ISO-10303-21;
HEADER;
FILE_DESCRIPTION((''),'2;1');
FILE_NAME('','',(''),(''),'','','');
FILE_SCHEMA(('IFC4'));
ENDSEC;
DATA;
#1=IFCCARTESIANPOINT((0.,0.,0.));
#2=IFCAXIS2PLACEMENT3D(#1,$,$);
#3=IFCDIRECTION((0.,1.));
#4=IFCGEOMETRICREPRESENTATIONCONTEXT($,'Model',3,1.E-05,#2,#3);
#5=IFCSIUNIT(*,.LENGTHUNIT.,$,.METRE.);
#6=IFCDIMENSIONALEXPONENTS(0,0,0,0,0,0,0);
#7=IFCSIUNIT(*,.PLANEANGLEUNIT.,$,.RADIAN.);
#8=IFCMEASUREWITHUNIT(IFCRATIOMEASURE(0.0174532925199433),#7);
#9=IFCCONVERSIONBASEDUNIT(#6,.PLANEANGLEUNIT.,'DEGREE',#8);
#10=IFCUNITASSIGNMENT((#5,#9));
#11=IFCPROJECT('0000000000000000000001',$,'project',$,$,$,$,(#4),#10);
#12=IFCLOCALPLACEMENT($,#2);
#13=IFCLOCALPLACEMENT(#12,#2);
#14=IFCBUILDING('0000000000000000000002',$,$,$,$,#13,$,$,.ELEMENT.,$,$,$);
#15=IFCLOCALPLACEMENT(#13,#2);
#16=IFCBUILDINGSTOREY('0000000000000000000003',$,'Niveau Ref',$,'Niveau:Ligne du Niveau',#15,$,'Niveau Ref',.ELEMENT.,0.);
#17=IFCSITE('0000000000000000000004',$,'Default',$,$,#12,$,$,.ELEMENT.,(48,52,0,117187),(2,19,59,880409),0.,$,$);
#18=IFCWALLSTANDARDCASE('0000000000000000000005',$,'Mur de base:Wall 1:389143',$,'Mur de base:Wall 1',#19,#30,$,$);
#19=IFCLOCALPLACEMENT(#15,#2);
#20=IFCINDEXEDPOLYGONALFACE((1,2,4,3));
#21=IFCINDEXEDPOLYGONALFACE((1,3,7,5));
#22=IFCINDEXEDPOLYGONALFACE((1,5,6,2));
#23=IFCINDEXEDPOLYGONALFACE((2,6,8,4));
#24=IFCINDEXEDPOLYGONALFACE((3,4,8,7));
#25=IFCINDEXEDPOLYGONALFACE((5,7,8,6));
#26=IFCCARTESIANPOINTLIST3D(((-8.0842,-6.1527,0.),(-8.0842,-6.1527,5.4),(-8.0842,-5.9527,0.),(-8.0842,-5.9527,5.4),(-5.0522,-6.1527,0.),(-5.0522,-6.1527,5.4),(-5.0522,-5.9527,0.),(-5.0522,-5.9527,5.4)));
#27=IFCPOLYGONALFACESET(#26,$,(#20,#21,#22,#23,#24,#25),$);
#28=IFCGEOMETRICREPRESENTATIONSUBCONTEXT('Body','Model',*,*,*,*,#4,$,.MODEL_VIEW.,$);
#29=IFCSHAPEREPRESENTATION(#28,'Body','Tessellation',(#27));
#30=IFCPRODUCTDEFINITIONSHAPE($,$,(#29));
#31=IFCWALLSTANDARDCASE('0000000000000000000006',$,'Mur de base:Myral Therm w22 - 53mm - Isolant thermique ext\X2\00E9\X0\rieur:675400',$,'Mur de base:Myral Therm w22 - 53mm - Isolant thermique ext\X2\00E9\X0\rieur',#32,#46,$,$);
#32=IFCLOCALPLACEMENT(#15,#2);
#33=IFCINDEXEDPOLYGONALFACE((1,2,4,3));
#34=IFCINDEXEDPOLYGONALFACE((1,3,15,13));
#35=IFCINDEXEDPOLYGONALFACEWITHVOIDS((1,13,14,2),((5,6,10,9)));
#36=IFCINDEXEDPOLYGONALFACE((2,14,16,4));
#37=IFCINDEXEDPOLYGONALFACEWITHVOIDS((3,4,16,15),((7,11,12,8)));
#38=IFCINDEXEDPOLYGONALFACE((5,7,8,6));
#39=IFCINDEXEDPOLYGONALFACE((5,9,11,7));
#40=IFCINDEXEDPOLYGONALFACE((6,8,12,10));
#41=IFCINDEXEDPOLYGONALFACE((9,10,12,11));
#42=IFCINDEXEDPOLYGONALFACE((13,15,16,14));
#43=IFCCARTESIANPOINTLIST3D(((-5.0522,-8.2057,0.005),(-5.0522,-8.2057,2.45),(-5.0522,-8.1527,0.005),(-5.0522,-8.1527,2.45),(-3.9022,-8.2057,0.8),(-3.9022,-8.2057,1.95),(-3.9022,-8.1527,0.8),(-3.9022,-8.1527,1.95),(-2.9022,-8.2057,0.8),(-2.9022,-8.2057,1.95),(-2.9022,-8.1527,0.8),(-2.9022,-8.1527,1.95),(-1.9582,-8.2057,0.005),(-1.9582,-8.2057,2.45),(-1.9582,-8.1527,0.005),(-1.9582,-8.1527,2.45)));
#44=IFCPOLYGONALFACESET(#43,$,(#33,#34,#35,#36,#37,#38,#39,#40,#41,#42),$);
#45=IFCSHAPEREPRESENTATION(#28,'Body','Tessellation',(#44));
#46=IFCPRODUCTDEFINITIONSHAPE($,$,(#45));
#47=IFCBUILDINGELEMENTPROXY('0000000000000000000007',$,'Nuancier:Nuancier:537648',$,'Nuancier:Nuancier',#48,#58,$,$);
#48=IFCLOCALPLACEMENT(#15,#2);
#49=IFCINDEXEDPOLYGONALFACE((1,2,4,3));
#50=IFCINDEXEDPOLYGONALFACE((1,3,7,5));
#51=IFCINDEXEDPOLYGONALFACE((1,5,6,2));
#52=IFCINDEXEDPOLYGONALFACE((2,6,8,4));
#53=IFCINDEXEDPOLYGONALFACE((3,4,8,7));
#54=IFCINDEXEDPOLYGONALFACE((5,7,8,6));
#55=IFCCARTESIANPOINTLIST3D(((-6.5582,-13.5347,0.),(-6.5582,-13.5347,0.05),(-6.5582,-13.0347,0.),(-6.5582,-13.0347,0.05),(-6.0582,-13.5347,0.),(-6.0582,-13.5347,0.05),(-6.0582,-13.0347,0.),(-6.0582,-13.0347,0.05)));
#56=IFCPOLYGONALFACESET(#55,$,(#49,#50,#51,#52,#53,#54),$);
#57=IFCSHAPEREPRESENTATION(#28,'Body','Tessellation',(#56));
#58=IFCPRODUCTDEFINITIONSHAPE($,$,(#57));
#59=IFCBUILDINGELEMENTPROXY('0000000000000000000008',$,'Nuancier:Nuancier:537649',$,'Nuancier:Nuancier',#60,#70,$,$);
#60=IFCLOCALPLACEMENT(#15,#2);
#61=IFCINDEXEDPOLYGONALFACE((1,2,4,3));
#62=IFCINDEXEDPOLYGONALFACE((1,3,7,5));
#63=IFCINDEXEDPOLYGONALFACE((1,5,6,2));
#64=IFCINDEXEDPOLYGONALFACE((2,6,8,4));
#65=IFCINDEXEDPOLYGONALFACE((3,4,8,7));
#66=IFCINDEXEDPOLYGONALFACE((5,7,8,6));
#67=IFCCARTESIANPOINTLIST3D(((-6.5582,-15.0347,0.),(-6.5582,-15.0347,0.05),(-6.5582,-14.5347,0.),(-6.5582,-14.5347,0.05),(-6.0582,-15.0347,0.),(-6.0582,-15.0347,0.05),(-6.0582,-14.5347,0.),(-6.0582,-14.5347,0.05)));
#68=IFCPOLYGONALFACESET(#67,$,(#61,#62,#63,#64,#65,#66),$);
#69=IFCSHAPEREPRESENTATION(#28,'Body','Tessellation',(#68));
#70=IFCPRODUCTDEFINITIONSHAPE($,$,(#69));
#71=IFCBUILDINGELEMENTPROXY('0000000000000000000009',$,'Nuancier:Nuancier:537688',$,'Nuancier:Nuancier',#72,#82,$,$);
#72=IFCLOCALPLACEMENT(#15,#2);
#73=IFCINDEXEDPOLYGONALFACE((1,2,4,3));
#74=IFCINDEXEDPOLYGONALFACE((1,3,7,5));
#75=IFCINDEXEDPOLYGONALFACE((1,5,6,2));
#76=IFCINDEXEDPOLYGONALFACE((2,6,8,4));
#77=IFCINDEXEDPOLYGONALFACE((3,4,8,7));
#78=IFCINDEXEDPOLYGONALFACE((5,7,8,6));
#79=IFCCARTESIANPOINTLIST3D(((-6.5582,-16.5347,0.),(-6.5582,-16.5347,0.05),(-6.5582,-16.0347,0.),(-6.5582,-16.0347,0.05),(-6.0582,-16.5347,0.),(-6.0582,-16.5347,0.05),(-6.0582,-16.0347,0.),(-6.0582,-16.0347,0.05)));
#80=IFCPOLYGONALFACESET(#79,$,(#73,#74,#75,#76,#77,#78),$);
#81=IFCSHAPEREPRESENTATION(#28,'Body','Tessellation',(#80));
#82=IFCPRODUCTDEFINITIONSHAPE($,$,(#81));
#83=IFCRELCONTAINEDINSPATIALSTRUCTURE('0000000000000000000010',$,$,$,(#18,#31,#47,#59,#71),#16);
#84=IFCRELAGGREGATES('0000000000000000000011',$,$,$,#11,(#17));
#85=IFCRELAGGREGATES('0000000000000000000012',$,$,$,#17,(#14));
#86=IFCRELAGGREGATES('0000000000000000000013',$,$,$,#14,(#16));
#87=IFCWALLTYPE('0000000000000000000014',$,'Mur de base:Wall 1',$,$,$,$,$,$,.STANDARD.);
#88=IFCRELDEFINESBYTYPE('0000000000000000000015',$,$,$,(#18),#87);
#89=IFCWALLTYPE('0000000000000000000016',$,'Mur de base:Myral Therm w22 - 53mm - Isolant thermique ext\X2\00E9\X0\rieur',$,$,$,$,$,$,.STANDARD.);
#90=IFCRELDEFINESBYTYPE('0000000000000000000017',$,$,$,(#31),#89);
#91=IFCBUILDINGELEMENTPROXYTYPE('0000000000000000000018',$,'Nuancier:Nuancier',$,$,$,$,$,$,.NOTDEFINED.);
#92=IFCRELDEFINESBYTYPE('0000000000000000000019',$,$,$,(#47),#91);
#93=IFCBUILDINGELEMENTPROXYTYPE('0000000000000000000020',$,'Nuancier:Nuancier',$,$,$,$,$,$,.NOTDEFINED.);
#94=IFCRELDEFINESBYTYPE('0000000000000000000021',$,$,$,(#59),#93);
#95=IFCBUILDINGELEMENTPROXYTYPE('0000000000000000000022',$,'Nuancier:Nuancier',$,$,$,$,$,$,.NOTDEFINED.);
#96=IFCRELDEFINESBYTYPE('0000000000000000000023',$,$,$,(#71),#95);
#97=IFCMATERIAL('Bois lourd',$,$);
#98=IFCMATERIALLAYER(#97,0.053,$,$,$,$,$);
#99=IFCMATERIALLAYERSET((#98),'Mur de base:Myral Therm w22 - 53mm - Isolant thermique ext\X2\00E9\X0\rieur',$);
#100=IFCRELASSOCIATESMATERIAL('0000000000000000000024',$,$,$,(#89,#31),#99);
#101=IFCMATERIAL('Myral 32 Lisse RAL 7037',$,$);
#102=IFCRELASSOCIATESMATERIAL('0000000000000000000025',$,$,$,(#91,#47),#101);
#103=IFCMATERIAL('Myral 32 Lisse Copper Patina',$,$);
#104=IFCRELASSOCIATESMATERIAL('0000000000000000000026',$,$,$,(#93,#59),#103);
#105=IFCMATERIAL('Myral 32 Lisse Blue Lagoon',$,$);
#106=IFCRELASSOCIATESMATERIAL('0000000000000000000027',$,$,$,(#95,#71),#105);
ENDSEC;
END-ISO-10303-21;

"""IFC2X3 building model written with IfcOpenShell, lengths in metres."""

from ifc_helpers import new_model, entity, si_unit, converted_unit, direction, frame, frame_2d, origin, origin_2d_with_axis, place, context, subcontext, project, spatial, rectangle, extrude, source, transform, mapped, material, layer, layer_set, layer_usage, type_object, type_shapes, element, save


model = new_model("IFC2X3")

# Units and contexts
model_context = context("Model", 3, precision=1e-05, world=origin(), true_north=direction((0.0, 1.0)))
body_context = subcontext(model_context, "Body", "Model", "MODEL_VIEW")
ifc_project = project(units=[si_unit("LENGTHUNIT", "METRE"), converted_unit("PLANEANGLEUNIT", "DEGREE", entity("IfcRatioMeasure", 0.0174532925199433), si_unit("PLANEANGLEUNIT", "RADIAN"), dimensions=[0, 0, 0, 0, 0, 0, 0])], contexts=[model_context])

# Site, building, storey
site_placement = place(None, origin())
site = spatial("IfcSite", under=ifc_project, at=site_placement, Name="Default", CompositionType="ELEMENT", RefLatitude=(48, 52, 0, 117187), RefLongitude=(2, 19, 59, 880409), RefElevation=0.0)
building_placement = place(site_placement, origin())
building = spatial("IfcBuilding", under=site, at=building_placement, CompositionType="ELEMENT")
storey_placement = place(building_placement, origin())
storey = spatial("IfcBuildingStorey", under=building, at=storey_placement, Name="Niveau Ref", ObjectType="Niveau:Ligne du Niveau", LongName="Niveau Ref", CompositionType="ELEMENT", Elevation=0.0)

# Wall
wall_type_1 = type_object("IfcWallType", Name="Mur de base:Wall 1", PredefinedType="STANDARD")
wall_1_placement = place(storey_placement, frame((-5.0522, -6.0527, 0.0), z_axis=(0.0, 0.0, 1.0), x_axis=(-1.0, 0.0, 0.0)))
element("IfcWallStandardCase", 1, at=wall_1_placement, inside=storey, type_object=wall_type_1, Name="Mur de base:Wall 1:389143", ObjectType="Mur de base:Wall 1", context=body_context, shape_type="SweptSolid", body=[
    extrude(rectangle(XDim=3.032, YDim=0.2, at=frame_2d((1.516, 0.0), x_axis=(-1.0, 0.0))), origin(), (0.0, 0.0, 1.0), 5.4),
])

# Wall, opening
ifc_material_1 = material(Name="Bois lourd")
ifc_layer = layer(ifc_material_1, 0.053)
ifc_layer_set = layer_set([ifc_layer], Name="Mur de base:Myral Therm w22 - 53mm - Isolant thermique extérieur")
ifc_layer_usage = layer_usage(ifc_layer_set, "AXIS2", "NEGATIVE", 0.0265)
wall_type_2 = type_object("IfcWallType", Name="Mur de base:Myral Therm w22 - 53mm - Isolant thermique extérieur", PredefinedType="STANDARD", material=ifc_layer_set)
wall_2_placement = place(storey_placement, frame((-5.0522, -8.1792, 0.005)))
wall_2 = element("IfcWallStandardCase", 2, at=wall_2_placement, inside=storey, type_object=wall_type_2, material=ifc_layer_usage, Name="Mur de base:Myral Therm w22 - 53mm - Isolant thermique extérieur:675400", ObjectType="Mur de base:Myral Therm w22 - 53mm - Isolant thermique extérieur", context=body_context, shape_type="SweptSolid", body=[
    extrude(rectangle(XDim=3.094, YDim=0.053, at=frame_2d((1.547, 0.0), x_axis=(-1.0, 0.0))), origin(), (0.0, 0.0, 1.0), 2.445),
])
opening_placement = place(wall_2_placement, origin())
element("IfcOpeningElement", 3, at=opening_placement, cuts=wall_2, ObjectType="Opening", context=body_context, shape_type="SweptSolid", body=[
    extrude(rectangle(XDim=1.15, YDim=1.0, at=frame_2d((0.0, 0.0), x_axis=(0.0, 1.0))), frame((1.65, 0.0265, 1.37), z_axis=(0.0, -1.0, 0.0), x_axis=(-1.0, 0.0, 0.0)), (0.0, 0.0, 1.0), 0.053),
])

# Building element proxies
ifc_material_2 = material(Name="Myral 32 Lisse RAL 7037")
building_element_proxy_type_1 = type_object("IfcBuildingElementProxyType", Name="Nuancier:Nuancier", PredefinedType="NOTDEFINED", material=ifc_material_2)
shared_shape_1 = source(origin(), body_context, "Body", "SweptSolid", [
    extrude(rectangle(XDim=0.5, YDim=0.5, at=origin_2d_with_axis()), frame((0.0, 0.0, 0.0), z_axis=(0.0, 0.0, 1.0), x_axis=(-1.0, 0.0, 0.0)), (0.0, 0.0, 1.0), 0.05),
])
type_shapes(building_element_proxy_type_1, [shared_shape_1])
proxy_1_placement = place(storey_placement, frame((-6.3082, -13.2847, 0.0)))
element("IfcBuildingElementProxy", 4, at=proxy_1_placement, inside=storey, type_object=building_element_proxy_type_1, material=ifc_material_2, Name="Nuancier:Nuancier:537648", ObjectType="Nuancier:Nuancier", context=body_context, shape_type="MappedRepresentation", body=[
    mapped(shared_shape_1, transform((0.0, 0.0, 0.0), scale=1.0)),
])
ifc_material_3 = material(Name="Myral 32 Lisse Copper Patina")
building_element_proxy_type_2 = type_object("IfcBuildingElementProxyType", Name="Nuancier:Nuancier", PredefinedType="NOTDEFINED", material=ifc_material_3)
shared_shape_2 = source(origin(), body_context, "Body", "SweptSolid", [
    extrude(rectangle(XDim=0.5, YDim=0.5, at=origin_2d_with_axis()), frame((0.0, 0.0, 0.0), z_axis=(0.0, 0.0, 1.0), x_axis=(-1.0, 0.0, 0.0)), (0.0, 0.0, 1.0), 0.05),
])
type_shapes(building_element_proxy_type_2, [shared_shape_2])
proxy_2_placement = place(storey_placement, frame((-6.3082, -14.7847, 0.0)))
element("IfcBuildingElementProxy", 5, at=proxy_2_placement, inside=storey, type_object=building_element_proxy_type_2, material=ifc_material_3, Name="Nuancier:Nuancier:537649", ObjectType="Nuancier:Nuancier", context=body_context, shape_type="MappedRepresentation", body=[
    mapped(shared_shape_2, transform((0.0, 0.0, 0.0), scale=1.0)),
])
ifc_material_4 = material(Name="Myral 32 Lisse Blue Lagoon")
building_element_proxy_type_3 = type_object("IfcBuildingElementProxyType", Name="Nuancier:Nuancier", PredefinedType="NOTDEFINED", material=ifc_material_4)
shared_shape_3 = source(origin(), body_context, "Body", "SweptSolid", [
    extrude(rectangle(XDim=0.5, YDim=0.5, at=origin_2d_with_axis()), frame((0.0, 0.0, 0.0), z_axis=(0.0, 0.0, 1.0), x_axis=(-1.0, 0.0, 0.0)), (0.0, 0.0, 1.0), 0.05),
])
type_shapes(building_element_proxy_type_3, [shared_shape_3])
proxy_3_placement = place(storey_placement, frame((-6.3082, -16.2847, 0.0)))
element("IfcBuildingElementProxy", 6, at=proxy_3_placement, inside=storey, type_object=building_element_proxy_type_3, material=ifc_material_4, Name="Nuancier:Nuancier:537688", ObjectType="Nuancier:Nuancier", context=body_context, shape_type="MappedRepresentation", body=[
    mapped(shared_shape_3, transform((0.0, 0.0, 0.0), scale=1.0)),
])

save(model, "model.ifc")
